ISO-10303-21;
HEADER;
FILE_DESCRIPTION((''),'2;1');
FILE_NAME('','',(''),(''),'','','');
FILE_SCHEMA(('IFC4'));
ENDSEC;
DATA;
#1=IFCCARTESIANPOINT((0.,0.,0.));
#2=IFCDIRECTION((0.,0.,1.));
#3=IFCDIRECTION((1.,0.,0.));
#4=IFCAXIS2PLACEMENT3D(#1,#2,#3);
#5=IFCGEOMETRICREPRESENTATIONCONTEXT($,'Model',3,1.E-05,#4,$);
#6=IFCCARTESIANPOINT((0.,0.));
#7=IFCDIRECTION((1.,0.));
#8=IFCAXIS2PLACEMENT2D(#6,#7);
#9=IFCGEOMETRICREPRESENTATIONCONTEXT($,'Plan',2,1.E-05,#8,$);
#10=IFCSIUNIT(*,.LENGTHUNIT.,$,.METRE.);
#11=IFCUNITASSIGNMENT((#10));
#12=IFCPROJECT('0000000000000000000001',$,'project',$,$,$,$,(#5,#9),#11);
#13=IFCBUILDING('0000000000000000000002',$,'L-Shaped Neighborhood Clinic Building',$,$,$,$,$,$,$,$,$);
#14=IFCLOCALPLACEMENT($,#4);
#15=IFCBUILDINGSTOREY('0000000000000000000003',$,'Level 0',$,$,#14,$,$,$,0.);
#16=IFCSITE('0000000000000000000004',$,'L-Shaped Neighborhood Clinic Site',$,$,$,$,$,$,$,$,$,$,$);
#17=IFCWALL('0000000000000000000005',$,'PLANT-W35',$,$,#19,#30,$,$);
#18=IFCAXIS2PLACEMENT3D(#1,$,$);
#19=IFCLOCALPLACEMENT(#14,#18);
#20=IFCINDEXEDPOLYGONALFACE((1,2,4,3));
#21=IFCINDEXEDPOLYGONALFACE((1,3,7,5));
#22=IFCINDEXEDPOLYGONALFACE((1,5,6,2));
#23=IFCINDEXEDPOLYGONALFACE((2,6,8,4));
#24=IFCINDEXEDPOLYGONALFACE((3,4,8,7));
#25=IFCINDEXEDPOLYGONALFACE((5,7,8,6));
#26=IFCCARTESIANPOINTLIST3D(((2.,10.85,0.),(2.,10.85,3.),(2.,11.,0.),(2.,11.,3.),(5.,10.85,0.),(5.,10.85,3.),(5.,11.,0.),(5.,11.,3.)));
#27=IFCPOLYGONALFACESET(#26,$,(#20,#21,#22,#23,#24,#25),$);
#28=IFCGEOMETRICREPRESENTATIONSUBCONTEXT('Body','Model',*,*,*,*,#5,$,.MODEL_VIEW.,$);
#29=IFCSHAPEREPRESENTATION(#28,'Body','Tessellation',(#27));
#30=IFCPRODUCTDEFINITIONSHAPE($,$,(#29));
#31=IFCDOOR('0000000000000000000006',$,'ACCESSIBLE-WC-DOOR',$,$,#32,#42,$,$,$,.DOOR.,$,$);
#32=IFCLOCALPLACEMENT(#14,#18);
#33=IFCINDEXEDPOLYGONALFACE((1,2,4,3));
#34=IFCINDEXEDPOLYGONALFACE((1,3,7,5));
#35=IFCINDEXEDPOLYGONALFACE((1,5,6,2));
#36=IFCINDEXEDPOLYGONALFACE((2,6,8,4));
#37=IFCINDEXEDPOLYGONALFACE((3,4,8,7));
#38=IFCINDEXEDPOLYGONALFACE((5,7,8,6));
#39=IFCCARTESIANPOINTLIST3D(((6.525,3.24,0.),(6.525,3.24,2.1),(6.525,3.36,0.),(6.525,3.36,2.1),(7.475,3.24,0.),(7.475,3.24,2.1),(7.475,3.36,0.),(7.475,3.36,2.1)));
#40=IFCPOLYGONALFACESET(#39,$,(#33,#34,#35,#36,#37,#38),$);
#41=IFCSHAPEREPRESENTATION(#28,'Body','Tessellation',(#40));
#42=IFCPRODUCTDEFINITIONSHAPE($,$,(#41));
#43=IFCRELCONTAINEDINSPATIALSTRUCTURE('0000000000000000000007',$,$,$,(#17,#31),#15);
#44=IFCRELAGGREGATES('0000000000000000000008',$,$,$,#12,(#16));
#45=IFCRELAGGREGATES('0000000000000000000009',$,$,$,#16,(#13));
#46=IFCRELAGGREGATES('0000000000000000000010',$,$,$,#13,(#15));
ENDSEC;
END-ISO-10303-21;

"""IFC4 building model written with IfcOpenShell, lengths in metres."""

from ifc_helpers import new_model, si_unit, frame, origin, origin_with_axes, origin_2d, origin_2d_with_axis, place, context, subcontext, project, spatial, indexed_curve, rectangle, outline, extrude, element, save


model = new_model("IFC4")

# Units and contexts
model_context = context("Model", 3, precision=1e-05, world=origin_with_axes())
plan_context = context("Plan", 2, precision=1e-05, world=origin_2d_with_axis())
body_context = subcontext(model_context, "Body", "Model", "MODEL_VIEW")
ifc_project = project(units=[si_unit("LENGTHUNIT", "METRE")], contexts=[model_context, plan_context])

# Site, building, storey
site = spatial("IfcSite", under=ifc_project, Name="L-Shaped Neighborhood Clinic Site")
building = spatial("IfcBuilding", under=site, Name="L-Shaped Neighborhood Clinic Building")
storey_placement = place(None, origin_with_axes())
storey = spatial("IfcBuildingStorey", under=building, at=storey_placement, Name="Level 0", Elevation=0.0)

# Wall
wall_1_placement = place(storey_placement, frame((5.0, 11.0, 0.0), z_axis=(0.0, 0.0, 1.0), x_axis=(-1.0, 0.0, 0.0)))
element("IfcWall", 1, at=wall_1_placement, inside=storey, Name="PLANT-W35", context=body_context, shape_type="SweptSolid", body=[
    extrude(outline(indexed_curve([(0.0, 0.0), (0.0, 0.15), (3.0, 0.15), (3.0, 0.0), (0.0, 0.0)], self_intersect=False)), origin_with_axes(), (0.0, 0.0, 1.0), 3.0),
])

# Door
door_placement = place(None, frame((7.0, 3.3, 0.0)))
element("IfcDoor", 2, at=door_placement, inside=storey, Name="ACCESSIBLE-WC-DOOR", PredefinedType="DOOR", context=body_context, shape_type="SweptSolid", body=[
    extrude(rectangle(XDim=0.95, YDim=0.12, at=origin_2d()), origin(), (0.0, 0.0, 1.0), 2.1),
])

save(model, "model.ifc")
